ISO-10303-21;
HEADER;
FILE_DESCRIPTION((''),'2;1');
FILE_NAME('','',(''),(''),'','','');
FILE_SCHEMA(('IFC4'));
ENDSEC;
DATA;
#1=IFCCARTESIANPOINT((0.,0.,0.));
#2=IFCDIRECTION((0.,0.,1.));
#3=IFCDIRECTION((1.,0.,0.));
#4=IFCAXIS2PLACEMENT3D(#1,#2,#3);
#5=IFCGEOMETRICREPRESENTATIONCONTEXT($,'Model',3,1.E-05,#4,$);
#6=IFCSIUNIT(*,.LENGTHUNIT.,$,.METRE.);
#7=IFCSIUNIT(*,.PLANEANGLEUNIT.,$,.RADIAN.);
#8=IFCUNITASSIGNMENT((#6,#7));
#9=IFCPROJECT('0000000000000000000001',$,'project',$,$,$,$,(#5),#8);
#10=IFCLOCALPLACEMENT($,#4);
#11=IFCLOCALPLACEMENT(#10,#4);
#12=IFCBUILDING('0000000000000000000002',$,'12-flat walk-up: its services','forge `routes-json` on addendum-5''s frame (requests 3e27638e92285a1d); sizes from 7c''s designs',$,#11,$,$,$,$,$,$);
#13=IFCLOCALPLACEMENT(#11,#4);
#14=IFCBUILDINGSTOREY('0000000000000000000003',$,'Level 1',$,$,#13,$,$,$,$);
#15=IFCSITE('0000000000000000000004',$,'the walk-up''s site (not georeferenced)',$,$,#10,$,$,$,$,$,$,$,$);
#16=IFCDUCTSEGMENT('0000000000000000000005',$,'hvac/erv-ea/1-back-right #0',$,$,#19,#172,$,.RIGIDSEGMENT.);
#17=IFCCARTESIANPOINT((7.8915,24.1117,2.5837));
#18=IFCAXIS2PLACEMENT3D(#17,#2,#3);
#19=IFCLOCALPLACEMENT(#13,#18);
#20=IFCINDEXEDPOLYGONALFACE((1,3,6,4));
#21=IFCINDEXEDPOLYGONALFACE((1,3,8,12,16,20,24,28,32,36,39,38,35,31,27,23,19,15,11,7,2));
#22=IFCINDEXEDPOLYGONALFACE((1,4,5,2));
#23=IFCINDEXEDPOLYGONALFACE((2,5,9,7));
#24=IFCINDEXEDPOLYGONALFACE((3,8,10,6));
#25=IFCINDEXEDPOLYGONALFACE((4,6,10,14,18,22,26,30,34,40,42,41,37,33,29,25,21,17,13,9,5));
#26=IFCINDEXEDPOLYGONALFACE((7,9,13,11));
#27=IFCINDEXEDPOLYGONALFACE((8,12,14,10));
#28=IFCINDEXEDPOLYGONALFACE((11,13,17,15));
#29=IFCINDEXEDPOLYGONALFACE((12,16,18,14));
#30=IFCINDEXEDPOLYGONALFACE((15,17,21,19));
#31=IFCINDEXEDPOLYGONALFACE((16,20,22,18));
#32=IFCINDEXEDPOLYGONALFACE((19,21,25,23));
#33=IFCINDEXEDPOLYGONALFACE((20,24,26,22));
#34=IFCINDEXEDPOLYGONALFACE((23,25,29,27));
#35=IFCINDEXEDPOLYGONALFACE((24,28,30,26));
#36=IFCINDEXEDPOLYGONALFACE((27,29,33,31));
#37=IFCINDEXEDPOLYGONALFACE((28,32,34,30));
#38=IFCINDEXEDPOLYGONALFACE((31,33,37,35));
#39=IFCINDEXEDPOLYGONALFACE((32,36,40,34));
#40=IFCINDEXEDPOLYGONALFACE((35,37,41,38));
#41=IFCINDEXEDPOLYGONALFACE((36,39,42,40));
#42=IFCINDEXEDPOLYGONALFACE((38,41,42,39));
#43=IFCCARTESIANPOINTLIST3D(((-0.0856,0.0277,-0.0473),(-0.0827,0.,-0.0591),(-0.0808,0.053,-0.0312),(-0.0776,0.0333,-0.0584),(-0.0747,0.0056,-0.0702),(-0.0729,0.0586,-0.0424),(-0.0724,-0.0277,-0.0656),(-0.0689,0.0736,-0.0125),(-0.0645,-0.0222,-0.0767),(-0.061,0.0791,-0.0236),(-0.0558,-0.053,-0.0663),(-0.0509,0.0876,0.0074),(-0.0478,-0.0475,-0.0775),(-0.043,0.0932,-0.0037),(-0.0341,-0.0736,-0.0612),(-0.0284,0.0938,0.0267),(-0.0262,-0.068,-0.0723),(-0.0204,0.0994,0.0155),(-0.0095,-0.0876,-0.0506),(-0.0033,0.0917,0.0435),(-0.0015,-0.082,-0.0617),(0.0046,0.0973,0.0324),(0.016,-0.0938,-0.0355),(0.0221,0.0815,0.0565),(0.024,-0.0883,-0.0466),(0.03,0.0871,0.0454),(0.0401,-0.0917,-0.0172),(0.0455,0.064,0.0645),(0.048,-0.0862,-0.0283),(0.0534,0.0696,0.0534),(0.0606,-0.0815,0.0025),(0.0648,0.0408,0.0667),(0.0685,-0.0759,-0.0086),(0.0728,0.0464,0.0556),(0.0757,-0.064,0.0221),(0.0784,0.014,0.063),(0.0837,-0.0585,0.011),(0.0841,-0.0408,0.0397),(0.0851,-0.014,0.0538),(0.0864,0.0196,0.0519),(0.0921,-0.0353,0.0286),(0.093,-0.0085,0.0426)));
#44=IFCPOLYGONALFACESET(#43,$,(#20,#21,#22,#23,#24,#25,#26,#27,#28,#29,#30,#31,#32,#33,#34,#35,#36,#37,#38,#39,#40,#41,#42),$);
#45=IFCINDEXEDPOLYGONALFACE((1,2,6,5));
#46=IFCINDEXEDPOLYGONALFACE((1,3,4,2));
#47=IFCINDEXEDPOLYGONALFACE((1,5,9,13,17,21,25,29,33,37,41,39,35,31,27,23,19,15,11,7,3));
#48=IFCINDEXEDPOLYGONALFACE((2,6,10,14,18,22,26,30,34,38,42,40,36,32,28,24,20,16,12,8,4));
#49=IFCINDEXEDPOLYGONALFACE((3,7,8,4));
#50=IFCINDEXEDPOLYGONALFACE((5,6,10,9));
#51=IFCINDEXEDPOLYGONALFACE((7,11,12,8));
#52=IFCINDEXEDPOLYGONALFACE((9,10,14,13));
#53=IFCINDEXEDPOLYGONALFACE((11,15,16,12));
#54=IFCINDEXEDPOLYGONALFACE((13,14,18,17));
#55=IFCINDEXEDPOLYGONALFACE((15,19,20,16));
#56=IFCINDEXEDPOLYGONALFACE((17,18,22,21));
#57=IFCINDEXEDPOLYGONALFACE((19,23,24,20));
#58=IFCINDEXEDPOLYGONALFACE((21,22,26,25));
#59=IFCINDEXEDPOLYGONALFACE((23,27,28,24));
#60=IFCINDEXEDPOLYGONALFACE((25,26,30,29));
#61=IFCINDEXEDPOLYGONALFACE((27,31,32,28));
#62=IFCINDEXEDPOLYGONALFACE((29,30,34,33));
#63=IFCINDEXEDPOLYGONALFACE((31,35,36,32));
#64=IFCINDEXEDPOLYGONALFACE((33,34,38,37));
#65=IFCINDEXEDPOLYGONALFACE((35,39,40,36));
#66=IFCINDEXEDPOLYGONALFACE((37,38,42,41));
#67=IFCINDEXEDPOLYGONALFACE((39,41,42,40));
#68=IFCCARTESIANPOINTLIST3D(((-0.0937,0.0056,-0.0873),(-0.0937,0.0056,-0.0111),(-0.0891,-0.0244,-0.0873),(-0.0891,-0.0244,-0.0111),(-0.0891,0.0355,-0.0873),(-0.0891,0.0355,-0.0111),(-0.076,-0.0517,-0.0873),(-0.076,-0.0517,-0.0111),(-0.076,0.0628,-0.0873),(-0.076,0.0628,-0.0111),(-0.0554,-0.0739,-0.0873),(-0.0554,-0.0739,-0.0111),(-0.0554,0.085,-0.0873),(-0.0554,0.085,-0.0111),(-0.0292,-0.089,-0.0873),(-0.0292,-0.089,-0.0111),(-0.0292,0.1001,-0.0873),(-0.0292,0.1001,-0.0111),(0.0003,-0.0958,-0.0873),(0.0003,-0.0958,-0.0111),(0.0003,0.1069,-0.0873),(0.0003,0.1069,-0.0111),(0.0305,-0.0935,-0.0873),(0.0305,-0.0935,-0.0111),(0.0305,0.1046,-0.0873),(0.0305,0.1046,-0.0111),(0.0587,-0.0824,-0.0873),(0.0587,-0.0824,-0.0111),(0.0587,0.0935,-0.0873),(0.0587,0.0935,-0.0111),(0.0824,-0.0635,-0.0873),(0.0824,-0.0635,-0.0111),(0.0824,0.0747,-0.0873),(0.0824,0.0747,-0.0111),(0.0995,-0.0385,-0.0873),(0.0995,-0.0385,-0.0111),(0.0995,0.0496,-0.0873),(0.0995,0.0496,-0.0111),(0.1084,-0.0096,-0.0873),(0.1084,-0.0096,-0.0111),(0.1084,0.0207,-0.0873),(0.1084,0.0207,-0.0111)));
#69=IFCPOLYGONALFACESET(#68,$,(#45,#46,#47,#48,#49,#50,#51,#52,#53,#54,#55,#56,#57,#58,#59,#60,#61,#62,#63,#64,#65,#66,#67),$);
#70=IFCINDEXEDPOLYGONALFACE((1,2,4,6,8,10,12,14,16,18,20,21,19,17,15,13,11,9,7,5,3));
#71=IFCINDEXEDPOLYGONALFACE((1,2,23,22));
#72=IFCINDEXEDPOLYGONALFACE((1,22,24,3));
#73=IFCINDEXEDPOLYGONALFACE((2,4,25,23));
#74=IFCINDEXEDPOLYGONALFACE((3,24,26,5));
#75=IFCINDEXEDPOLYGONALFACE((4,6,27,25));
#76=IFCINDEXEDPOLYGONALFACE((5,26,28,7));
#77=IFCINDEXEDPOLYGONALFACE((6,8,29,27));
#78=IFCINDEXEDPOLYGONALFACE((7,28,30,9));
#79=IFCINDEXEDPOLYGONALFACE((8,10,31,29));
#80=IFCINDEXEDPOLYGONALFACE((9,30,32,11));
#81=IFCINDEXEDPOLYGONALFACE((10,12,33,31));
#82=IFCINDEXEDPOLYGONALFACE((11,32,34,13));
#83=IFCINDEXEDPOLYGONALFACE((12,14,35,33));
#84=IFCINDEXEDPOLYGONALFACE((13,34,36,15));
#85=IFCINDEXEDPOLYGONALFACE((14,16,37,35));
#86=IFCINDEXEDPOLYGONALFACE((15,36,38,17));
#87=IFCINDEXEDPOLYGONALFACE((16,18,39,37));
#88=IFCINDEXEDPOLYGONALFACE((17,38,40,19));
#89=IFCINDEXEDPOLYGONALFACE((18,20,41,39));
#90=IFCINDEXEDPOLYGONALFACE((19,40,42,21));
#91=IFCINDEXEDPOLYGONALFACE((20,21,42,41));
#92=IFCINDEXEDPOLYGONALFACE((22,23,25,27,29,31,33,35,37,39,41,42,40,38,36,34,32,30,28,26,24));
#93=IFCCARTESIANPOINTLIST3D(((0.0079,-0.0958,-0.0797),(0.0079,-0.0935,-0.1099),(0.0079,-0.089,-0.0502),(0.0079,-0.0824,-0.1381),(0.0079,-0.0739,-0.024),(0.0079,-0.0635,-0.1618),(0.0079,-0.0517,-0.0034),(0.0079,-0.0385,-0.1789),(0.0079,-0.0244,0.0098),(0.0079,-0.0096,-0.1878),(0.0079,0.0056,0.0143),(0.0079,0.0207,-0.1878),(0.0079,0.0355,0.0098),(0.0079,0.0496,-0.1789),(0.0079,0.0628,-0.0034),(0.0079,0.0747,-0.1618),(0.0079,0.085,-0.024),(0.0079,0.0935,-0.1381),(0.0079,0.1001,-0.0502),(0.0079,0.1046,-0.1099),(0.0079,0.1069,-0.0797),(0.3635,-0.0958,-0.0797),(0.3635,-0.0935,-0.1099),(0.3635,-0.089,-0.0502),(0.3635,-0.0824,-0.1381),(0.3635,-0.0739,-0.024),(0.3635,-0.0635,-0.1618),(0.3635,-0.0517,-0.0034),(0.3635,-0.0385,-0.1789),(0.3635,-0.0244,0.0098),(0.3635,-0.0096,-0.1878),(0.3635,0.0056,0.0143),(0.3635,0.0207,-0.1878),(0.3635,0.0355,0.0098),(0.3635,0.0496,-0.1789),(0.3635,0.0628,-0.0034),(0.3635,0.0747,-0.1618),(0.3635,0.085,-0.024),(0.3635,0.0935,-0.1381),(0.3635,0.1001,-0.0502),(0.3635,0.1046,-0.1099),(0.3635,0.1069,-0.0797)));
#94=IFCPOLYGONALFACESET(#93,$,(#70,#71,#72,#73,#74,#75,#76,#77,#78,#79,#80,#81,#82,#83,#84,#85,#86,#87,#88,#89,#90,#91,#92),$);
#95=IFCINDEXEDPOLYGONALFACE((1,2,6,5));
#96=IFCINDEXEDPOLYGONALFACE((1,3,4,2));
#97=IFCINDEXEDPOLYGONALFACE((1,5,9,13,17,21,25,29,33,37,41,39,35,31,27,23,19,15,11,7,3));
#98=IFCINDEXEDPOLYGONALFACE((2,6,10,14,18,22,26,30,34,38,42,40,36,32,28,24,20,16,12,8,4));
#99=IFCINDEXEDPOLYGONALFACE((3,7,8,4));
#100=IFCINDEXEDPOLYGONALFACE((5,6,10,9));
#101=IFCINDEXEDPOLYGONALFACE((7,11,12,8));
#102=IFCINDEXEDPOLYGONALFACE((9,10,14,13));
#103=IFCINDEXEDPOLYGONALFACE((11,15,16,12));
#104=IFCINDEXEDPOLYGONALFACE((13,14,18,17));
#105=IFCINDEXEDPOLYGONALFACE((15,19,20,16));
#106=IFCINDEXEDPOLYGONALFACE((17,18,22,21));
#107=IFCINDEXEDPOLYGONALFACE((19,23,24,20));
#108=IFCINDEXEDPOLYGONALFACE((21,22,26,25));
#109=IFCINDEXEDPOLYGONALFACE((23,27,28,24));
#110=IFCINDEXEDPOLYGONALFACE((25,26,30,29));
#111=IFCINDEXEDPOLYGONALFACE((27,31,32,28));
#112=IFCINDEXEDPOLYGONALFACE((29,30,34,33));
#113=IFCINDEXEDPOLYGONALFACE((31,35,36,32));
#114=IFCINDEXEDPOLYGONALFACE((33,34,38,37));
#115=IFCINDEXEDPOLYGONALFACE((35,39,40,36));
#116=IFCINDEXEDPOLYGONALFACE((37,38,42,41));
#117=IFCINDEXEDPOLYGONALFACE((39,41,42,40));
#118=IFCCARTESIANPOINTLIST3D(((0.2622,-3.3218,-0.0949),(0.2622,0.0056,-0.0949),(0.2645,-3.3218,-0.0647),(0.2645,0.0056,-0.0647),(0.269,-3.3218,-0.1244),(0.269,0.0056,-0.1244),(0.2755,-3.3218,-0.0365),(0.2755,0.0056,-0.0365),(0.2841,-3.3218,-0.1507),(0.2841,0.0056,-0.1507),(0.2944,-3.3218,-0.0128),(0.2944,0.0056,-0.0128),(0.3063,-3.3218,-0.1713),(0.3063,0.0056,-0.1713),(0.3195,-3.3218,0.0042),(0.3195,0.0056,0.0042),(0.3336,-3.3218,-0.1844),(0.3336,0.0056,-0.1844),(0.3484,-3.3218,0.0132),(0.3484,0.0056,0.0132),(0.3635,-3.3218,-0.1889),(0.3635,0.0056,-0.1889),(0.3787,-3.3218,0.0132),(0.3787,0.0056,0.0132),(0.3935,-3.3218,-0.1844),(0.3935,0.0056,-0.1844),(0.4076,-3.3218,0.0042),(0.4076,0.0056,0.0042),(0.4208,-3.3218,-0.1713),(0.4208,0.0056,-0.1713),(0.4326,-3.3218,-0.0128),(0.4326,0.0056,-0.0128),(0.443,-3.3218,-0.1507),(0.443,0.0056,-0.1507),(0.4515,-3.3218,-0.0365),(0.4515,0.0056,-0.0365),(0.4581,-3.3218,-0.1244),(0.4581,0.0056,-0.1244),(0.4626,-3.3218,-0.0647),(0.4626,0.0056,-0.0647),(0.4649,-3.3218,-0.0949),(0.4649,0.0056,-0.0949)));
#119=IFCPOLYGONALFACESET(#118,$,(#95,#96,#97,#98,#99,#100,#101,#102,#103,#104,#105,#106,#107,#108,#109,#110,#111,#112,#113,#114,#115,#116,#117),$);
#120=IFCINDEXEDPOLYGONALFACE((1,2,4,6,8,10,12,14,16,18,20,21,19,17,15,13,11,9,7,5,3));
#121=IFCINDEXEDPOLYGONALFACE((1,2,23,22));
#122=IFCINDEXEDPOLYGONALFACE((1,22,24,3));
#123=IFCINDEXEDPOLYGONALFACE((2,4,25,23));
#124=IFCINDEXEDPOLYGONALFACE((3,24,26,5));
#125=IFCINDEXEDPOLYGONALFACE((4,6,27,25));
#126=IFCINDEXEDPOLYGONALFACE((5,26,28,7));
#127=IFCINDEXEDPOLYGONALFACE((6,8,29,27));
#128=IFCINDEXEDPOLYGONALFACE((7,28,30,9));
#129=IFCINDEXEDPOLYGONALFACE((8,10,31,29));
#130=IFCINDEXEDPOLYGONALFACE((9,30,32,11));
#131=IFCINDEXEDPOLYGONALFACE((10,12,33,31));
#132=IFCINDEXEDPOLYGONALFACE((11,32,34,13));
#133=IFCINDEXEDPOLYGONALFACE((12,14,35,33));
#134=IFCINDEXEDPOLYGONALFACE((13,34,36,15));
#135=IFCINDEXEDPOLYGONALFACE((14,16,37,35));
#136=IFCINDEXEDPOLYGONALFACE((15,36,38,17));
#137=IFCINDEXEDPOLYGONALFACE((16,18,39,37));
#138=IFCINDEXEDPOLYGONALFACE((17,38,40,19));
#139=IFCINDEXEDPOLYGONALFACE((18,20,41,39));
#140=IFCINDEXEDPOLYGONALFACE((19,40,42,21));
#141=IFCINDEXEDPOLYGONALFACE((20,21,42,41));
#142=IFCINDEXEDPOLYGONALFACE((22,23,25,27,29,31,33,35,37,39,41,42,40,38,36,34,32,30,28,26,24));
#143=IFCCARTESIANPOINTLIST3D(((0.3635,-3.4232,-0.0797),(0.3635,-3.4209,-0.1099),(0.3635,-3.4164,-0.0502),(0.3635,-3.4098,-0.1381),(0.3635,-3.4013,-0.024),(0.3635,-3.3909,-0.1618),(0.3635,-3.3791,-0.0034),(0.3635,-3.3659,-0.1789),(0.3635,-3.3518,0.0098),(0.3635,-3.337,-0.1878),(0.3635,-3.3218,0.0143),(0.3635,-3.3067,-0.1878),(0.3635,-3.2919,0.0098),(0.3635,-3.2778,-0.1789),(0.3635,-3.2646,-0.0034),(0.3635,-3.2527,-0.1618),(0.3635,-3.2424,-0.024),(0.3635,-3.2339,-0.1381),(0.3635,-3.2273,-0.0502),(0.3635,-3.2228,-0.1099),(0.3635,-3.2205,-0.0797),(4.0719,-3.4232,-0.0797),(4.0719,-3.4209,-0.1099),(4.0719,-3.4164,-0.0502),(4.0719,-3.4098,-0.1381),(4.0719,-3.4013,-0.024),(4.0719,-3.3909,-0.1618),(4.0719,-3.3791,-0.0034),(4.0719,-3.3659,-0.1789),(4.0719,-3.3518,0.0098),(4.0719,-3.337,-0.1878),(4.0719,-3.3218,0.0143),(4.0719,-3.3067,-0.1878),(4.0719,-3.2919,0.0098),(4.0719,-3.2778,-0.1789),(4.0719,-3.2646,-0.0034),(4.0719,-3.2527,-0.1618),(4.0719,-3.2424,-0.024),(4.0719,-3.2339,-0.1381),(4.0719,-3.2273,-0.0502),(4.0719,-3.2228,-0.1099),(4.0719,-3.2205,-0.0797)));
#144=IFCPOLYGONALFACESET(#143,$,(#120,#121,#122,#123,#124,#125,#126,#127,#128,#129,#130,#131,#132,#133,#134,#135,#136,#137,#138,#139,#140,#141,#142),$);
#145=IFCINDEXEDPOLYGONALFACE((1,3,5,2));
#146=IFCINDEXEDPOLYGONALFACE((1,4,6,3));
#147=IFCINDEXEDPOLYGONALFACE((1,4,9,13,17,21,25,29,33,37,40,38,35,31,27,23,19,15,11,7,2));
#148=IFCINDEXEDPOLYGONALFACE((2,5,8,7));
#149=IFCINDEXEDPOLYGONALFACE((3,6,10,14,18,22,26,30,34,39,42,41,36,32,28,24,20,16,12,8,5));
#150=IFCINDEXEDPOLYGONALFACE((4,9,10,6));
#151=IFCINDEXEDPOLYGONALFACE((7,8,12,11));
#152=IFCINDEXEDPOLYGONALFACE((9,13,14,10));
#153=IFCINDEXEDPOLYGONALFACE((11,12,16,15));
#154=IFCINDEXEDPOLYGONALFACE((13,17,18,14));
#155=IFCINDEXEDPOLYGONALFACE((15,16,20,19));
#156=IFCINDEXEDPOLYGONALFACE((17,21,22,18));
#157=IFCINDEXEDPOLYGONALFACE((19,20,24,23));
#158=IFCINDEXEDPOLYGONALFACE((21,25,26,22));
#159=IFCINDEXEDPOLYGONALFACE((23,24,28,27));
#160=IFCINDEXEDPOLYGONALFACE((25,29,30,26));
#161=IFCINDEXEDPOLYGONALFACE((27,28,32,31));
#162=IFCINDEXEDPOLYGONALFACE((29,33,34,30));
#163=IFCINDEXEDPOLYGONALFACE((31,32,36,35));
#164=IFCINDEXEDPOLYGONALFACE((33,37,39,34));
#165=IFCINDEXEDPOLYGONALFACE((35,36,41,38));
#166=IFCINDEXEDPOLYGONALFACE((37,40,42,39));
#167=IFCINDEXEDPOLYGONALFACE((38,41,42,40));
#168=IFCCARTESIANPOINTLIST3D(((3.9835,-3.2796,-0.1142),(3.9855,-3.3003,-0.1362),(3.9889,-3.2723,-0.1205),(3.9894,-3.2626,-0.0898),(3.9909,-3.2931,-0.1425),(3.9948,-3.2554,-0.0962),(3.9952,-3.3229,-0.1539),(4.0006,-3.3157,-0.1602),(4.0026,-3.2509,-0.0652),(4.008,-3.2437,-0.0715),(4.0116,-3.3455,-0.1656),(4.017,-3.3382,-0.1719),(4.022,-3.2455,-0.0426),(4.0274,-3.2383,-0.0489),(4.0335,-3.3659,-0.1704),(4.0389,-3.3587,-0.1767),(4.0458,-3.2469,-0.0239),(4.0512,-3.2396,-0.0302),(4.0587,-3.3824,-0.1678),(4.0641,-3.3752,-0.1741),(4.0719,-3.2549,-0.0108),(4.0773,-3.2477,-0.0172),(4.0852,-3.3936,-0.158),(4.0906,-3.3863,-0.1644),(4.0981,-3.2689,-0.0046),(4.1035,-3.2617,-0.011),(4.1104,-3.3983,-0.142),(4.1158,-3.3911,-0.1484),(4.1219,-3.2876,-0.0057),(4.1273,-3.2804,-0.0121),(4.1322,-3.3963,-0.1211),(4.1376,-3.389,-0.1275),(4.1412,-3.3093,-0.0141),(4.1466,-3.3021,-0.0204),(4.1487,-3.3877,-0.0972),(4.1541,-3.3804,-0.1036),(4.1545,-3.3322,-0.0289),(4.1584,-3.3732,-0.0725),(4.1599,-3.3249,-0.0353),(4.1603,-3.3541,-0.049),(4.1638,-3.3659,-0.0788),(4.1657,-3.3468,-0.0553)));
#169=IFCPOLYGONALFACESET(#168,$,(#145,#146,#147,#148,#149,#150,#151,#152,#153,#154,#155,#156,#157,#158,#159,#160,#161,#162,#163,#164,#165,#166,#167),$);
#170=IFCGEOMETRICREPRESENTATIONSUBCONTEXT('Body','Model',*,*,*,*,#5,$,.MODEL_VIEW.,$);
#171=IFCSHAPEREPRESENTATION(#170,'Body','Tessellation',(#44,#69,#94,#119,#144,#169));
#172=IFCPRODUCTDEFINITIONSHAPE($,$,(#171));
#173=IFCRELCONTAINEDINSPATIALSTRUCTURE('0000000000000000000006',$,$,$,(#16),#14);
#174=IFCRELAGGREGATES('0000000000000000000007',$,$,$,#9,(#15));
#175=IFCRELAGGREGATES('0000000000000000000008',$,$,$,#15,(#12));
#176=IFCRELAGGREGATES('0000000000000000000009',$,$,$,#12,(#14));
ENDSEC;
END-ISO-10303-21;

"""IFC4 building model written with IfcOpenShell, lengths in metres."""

from ifc_helpers import new_model, entity, si_unit, frame, origin_with_axes, place, context, subcontext, project, spatial, element, save


model = new_model("IFC4")

# Units and contexts
model_context = context("Model", 3, precision=1e-05, world=origin_with_axes())
body_context = subcontext(model_context, "Body", "Model", "MODEL_VIEW")
ifc_project = project(units=[si_unit("LENGTHUNIT", "METRE"), si_unit("PLANEANGLEUNIT", "RADIAN")], contexts=[model_context])

# Site, building, storey
site_placement = place(None, origin_with_axes())
site = spatial("IfcSite", under=ifc_project, at=site_placement, Name="the walk-up's site (not georeferenced)")
building_placement = place(site_placement, origin_with_axes())
building = spatial("IfcBuilding", under=site, at=building_placement, Name="12-flat walk-up: its services", Description="forge `routes-json` on addendum-5's frame (requests 3e27638e92285a1d); sizes from 7c's designs")
storey_placement = place(building_placement, origin_with_axes())
storey = spatial("IfcBuildingStorey", under=building, at=storey_placement, Name="Level 1")

# Duct segment
duct_segment_1_placement = place(storey_placement, frame((7.8915, 24.1117, 2.5837), z_axis=(0.0, 0.0, 1.0), x_axis=(1.0, 0.0, 0.0)))
element("IfcDuctSegment", 1, at=duct_segment_1_placement, inside=storey, Name="hvac/erv-ea/1-back-right #0", PredefinedType="RIGIDSEGMENT", context=body_context, shape_type="AdvancedSweptSolid", body=[
    entity("IfcSweptDiskSolid", entity("IfcPolyline", [entity("IfcCartesianPoint", [0.0, 0.0, 0.0]), entity("IfcCartesianPoint", [0.0079, 0.0056, -0.0111])]), 0.1016),
    entity("IfcSweptDiskSolid", entity("IfcPolyline", [entity("IfcCartesianPoint", [0.0079, 0.0056, -0.0111]), entity("IfcCartesianPoint", [0.0079, 0.0056, -0.0873])]), 0.1016),
    entity("IfcSweptDiskSolid", entity("IfcPolyline", [entity("IfcCartesianPoint", [0.0079, 0.0056, -0.0873]), entity("IfcCartesianPoint", [0.3635, 0.0056, -0.0873])]), 0.1016),
    entity("IfcSweptDiskSolid", entity("IfcPolyline", [entity("IfcCartesianPoint", [0.3635, 0.0056, -0.0873]), entity("IfcCartesianPoint", [0.3635, -3.3218, -0.0873])]), 0.1016),
    entity("IfcSweptDiskSolid", entity("IfcPolyline", [entity("IfcCartesianPoint", [0.3635, -3.3218, -0.0873]), entity("IfcCartesianPoint", [4.0719, -3.3218, -0.0873])]), 0.1016),
    entity("IfcSweptDiskSolid", entity("IfcPolyline", [entity("IfcCartesianPoint", [4.0719, -3.3218, -0.0873]), entity("IfcCartesianPoint", [4.0773, -3.3146, -0.0937])]), 0.1016),
])

save(model, "model.ifc")
